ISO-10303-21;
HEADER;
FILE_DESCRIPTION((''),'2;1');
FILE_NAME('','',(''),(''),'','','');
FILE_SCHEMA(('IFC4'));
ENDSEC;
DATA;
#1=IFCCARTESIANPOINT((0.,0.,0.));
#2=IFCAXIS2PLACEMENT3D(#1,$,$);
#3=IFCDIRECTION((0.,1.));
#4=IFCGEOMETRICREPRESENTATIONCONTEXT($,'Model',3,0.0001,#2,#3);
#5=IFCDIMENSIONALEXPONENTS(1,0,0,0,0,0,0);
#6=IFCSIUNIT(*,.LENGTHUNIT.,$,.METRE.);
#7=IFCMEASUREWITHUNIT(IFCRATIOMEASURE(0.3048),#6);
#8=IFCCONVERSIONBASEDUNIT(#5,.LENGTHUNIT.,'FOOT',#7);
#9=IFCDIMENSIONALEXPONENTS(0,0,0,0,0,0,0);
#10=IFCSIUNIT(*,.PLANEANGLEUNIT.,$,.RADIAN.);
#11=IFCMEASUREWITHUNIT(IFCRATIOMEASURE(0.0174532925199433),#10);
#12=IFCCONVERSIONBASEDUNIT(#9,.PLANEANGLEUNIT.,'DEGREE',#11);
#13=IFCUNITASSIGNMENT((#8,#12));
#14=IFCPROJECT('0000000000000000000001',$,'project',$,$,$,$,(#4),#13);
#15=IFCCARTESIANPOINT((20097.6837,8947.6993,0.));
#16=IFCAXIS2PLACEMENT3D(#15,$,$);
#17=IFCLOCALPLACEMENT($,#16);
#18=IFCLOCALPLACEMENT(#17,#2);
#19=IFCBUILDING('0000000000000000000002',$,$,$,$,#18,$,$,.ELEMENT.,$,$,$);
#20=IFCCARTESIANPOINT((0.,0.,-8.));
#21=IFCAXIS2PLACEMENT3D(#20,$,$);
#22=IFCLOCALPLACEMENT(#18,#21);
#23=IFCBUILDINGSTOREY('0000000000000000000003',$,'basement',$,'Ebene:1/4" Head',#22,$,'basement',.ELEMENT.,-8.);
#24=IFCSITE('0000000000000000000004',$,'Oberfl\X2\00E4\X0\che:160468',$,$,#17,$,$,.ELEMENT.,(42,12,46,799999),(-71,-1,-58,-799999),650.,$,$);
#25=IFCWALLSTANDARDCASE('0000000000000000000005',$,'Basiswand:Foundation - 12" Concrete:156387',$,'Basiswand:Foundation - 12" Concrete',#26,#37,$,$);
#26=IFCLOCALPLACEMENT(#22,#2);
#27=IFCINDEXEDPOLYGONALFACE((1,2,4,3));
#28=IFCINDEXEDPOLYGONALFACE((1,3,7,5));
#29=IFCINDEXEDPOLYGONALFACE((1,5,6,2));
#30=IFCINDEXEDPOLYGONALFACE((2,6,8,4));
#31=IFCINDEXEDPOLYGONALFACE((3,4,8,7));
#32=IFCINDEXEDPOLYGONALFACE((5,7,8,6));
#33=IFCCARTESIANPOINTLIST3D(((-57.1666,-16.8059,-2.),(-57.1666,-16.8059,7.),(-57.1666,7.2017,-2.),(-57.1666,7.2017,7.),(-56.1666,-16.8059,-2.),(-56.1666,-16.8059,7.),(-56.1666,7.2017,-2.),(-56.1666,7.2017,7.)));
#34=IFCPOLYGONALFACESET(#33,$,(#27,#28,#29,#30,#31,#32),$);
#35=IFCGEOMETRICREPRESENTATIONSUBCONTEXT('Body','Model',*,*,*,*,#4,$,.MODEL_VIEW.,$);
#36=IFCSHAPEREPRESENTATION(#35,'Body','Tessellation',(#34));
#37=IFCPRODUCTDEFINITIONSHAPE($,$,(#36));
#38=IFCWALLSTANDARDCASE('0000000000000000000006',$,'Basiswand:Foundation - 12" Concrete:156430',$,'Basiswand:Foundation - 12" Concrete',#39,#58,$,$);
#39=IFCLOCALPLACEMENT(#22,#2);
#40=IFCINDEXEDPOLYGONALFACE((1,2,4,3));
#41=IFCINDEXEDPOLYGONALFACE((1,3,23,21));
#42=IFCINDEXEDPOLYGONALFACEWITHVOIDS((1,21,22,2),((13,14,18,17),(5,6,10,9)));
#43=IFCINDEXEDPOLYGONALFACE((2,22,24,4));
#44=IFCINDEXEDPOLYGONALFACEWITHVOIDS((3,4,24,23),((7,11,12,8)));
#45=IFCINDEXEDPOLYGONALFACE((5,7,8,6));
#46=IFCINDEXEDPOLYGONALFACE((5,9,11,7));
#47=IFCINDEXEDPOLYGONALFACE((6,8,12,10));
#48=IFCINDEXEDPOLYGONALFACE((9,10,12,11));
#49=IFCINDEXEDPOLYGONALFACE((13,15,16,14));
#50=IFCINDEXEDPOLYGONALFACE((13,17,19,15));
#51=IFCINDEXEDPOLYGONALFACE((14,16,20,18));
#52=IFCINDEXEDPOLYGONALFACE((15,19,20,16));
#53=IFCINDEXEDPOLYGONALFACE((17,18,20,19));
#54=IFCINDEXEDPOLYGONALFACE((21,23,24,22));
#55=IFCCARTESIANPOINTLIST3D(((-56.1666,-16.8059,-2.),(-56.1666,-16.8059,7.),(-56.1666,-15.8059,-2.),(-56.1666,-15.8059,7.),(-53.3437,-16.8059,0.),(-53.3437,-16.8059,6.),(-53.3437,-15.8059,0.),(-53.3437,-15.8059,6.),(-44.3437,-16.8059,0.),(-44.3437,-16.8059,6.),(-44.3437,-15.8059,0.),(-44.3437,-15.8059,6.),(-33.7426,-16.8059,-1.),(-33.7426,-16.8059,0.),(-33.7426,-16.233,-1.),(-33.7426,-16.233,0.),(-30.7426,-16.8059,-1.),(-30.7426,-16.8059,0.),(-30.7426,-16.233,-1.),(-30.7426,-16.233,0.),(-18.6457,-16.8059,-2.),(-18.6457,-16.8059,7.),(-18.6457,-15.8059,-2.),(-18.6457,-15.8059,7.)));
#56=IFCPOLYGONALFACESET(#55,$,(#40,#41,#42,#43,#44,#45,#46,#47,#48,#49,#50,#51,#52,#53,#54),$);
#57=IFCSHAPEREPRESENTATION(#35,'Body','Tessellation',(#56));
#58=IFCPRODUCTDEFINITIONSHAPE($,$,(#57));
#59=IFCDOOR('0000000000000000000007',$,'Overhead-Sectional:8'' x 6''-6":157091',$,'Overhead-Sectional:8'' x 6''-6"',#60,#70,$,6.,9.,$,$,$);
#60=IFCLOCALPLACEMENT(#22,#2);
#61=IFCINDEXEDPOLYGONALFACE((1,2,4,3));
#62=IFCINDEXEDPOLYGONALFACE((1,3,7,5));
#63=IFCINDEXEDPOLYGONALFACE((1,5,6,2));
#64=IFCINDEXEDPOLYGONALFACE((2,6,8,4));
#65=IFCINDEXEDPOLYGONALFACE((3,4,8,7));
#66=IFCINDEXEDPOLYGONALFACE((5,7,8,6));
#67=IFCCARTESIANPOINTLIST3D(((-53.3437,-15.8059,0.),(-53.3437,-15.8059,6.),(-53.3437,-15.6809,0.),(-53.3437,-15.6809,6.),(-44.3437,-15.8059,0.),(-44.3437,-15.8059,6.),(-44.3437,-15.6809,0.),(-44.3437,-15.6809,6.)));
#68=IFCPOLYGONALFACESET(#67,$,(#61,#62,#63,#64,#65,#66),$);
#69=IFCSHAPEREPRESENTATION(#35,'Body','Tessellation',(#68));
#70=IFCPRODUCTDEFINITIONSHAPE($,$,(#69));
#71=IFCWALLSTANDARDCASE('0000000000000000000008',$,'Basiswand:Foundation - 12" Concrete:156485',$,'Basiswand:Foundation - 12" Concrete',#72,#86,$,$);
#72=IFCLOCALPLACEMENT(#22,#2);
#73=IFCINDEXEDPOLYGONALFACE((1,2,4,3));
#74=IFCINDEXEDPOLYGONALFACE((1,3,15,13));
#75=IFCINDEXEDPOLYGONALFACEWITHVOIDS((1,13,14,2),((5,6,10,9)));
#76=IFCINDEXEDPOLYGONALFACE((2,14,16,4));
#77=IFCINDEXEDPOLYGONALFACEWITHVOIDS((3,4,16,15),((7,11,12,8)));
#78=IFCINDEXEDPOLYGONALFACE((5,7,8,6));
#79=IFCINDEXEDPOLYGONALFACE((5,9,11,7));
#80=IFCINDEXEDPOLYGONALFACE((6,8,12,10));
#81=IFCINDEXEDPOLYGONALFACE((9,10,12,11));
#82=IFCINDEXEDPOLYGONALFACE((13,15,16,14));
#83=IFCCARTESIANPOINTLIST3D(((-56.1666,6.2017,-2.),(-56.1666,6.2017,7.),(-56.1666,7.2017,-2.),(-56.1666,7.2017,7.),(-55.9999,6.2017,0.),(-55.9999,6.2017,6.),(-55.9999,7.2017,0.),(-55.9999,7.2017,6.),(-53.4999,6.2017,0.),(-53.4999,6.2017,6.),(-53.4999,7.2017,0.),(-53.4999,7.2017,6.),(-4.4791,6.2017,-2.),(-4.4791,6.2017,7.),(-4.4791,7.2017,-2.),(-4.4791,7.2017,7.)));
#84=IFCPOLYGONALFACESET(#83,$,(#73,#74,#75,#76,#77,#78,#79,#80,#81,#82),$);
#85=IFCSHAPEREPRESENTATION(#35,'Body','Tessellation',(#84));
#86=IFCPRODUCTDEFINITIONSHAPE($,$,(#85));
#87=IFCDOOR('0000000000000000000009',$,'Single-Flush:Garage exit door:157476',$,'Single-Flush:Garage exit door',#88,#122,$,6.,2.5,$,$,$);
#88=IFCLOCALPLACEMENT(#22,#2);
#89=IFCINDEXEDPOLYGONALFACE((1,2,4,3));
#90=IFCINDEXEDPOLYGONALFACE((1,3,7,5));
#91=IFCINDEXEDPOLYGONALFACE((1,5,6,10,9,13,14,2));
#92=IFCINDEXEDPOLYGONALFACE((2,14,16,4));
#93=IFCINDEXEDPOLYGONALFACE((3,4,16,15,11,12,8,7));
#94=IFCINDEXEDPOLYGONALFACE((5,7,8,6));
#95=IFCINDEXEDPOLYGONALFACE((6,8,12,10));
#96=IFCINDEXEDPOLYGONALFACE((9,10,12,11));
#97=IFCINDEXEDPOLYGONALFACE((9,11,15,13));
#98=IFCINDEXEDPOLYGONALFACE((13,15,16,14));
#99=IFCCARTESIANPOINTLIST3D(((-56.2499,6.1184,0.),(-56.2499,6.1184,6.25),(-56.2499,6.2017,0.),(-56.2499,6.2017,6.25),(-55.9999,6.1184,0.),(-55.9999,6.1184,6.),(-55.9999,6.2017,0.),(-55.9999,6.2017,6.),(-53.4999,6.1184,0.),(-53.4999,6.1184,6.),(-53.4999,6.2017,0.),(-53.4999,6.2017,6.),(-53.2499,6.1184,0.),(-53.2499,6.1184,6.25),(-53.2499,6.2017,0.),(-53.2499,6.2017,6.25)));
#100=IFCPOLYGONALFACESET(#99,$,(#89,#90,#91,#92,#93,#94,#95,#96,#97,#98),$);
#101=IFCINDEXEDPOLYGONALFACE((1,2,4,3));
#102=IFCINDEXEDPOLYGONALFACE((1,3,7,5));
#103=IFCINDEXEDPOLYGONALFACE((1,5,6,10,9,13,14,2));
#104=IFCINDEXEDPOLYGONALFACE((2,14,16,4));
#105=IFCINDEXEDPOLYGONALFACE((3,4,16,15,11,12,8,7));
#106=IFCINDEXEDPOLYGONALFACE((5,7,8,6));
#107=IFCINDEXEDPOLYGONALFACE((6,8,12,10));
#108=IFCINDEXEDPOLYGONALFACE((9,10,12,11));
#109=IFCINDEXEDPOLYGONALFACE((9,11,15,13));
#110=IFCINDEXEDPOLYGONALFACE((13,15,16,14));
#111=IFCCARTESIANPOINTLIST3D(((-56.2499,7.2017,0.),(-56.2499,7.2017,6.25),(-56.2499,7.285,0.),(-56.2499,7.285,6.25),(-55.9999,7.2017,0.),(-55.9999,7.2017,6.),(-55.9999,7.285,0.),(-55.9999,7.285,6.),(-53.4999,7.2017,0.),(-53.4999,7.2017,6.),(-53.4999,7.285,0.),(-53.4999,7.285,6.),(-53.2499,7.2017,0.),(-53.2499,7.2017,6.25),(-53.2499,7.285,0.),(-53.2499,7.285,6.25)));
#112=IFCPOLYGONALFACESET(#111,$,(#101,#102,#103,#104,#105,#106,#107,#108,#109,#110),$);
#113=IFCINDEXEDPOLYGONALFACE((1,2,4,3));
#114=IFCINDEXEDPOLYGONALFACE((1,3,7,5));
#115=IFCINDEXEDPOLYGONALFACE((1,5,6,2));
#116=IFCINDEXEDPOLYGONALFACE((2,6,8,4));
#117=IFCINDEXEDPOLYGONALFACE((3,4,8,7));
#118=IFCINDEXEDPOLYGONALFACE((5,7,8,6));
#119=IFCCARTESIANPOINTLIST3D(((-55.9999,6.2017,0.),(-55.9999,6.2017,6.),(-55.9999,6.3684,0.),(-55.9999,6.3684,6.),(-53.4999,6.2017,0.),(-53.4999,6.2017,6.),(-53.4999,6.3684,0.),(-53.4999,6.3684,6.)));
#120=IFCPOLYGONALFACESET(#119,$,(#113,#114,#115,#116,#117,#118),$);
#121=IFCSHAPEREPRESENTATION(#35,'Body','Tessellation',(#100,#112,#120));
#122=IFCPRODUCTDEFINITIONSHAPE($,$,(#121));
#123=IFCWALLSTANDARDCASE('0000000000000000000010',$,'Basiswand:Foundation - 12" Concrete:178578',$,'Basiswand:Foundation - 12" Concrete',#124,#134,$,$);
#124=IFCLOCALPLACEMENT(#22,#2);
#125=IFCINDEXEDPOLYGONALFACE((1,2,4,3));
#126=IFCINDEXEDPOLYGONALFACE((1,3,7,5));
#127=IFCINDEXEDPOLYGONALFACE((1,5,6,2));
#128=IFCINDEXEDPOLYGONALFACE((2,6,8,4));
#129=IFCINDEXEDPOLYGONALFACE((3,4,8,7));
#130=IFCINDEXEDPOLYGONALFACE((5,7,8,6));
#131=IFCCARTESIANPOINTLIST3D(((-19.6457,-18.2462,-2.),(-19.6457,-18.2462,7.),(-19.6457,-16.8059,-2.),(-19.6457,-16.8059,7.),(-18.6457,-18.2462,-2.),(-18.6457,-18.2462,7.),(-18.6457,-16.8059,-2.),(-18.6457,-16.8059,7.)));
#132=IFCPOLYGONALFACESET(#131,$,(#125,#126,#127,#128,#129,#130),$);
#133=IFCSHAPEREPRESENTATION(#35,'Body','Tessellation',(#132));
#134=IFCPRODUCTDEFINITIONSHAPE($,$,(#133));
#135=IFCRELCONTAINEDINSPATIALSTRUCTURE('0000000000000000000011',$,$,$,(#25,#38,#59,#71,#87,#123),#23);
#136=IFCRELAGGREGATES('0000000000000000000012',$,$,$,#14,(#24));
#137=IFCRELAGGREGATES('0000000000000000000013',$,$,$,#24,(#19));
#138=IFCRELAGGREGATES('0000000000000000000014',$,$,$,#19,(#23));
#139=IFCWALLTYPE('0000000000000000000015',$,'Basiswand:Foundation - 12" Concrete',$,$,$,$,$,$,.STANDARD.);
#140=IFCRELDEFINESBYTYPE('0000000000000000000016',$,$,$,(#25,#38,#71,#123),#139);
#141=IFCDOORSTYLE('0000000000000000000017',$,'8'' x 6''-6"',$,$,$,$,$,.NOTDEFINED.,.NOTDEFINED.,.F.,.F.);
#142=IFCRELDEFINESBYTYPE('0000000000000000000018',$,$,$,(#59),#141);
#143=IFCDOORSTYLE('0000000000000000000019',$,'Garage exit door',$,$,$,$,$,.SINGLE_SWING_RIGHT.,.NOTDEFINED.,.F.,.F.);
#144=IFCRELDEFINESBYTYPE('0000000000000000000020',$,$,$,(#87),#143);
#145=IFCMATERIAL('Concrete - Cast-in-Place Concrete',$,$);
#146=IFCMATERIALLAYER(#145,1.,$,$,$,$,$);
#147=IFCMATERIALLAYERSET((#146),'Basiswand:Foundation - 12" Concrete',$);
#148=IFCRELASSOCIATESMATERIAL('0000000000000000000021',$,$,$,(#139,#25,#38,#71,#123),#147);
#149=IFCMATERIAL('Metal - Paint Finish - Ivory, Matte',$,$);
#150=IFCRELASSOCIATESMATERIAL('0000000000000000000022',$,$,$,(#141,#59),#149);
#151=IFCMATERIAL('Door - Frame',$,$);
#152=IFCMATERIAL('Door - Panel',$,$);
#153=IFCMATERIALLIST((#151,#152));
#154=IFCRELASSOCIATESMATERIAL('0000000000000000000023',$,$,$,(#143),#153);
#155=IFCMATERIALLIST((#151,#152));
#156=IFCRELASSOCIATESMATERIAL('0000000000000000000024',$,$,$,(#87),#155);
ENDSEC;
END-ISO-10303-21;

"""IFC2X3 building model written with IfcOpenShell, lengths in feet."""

from ifc_helpers import new_model, entity, si_unit, converted_unit, direction, frame, frame_2d, origin, origin_2d_with_axis, place, context, subcontext, project, spatial, polyline, rectangle, outline, extrude, source, transform, mapped, material, material_list, layer, layer_set, layer_usage, type_object, type_shapes, element, fill, save


model = new_model("IFC2X3")

# Units and contexts
model_context = context("Model", 3, precision=0.0001, world=origin(), true_north=direction((0.0, 1.0)))
body_context = subcontext(model_context, "Body", "Model", "MODEL_VIEW")
ifc_project = project(units=[converted_unit("LENGTHUNIT", "FOOT", entity("IfcRatioMeasure", 0.3048), si_unit("LENGTHUNIT", "METRE"), dimensions=[1, 0, 0, 0, 0, 0, 0]), converted_unit("PLANEANGLEUNIT", "DEGREE", entity("IfcRatioMeasure", 0.0174532925199433), si_unit("PLANEANGLEUNIT", "RADIAN"), dimensions=[0, 0, 0, 0, 0, 0, 0])], contexts=[model_context])

# Site, building, storey
site_placement = place(None, frame((20097.6837, 8947.6993, 0.0)))
site = spatial("IfcSite", under=ifc_project, at=site_placement, Name="Oberfläche:160468", CompositionType="ELEMENT", RefLatitude=(42, 12, 46, 799999), RefLongitude=(-71, -1, -58, -799999), RefElevation=650.0)
building_placement = place(site_placement, origin())
building = spatial("IfcBuilding", under=site, at=building_placement, CompositionType="ELEMENT")
storey_placement = place(building_placement, frame((0.0, 0.0, -8.0)))
storey = spatial("IfcBuildingStorey", under=building, at=storey_placement, Name="basement", ObjectType="Ebene:1/4\" Head", LongName="basement", CompositionType="ELEMENT", Elevation=-8.0)

# Wall, opening
ifc_material_1 = material(Name="Concrete - Cast-in-Place Concrete")
ifc_layer_1 = layer(ifc_material_1, 1.0)
ifc_layer_set_1 = layer_set([ifc_layer_1], Name="Basiswand:Foundation - 12\" Concrete")
ifc_layer_usage_1 = layer_usage(ifc_layer_set_1, "AXIS2", "POSITIVE", -0.5)
wall_type_1 = type_object("IfcWallType", Name="Basiswand:Foundation - 12\" Concrete", PredefinedType="STANDARD", material=ifc_layer_set_1)
wall_1_placement = place(storey_placement, frame((-56.6666, 7.2017, -2.0), z_axis=(0.0, 0.0, 1.0), x_axis=(0.0, -1.0, 0.0)))
wall_1 = element("IfcWallStandardCase", 1, at=wall_1_placement, inside=storey, type_object=wall_type_1, material=ifc_layer_usage_1, Name="Basiswand:Foundation - 12\" Concrete:156387", ObjectType="Basiswand:Foundation - 12\" Concrete", context=body_context, shape_type="SweptSolid", body=[
    extrude(rectangle(XDim=24.0076, YDim=1.0, at=frame_2d((12.0038, 0.0), x_axis=(-1.0, 0.0))), origin(), (0.0, 0.0, 1.0), 9.0),
])
opening_1_placement = place(wall_1_placement, origin())
element("IfcOpeningElement", 2, at=opening_1_placement, cuts=wall_1, ObjectType="Opening", context=body_context, shape_type="SweptSolid", body=[
    extrude(rectangle(XDim=6.0, YDim=1.0, at=frame_2d((0.0, 0.0), x_axis=(0.0, 1.0))), frame((0.5, 0.6667, 5.0), z_axis=(0.0, 1.0, 0.0), x_axis=(1.0, 0.0, 0.0)), (0.0, 0.0, 1.0), 2.5),
])

# Wall, openings, door
ifc_layer_usage_2 = layer_usage(ifc_layer_set_1, "AXIS2", "POSITIVE", -0.5)
wall_2_placement = place(storey_placement, frame((-56.1666, -16.3059, -2.0)))
wall_2 = element("IfcWallStandardCase", 3, at=wall_2_placement, inside=storey, type_object=wall_type_1, material=ifc_layer_usage_2, Name="Basiswand:Foundation - 12\" Concrete:156430", ObjectType="Basiswand:Foundation - 12\" Concrete", context=body_context, shape_type="SweptSolid", body=[
    extrude(rectangle(XDim=37.5208, YDim=1.0, at=frame_2d((18.7604, 0.0), x_axis=(-1.0, 0.0))), origin(), (0.0, 0.0, 1.0), 9.0),
])
opening_2_placement = place(storey_placement, frame((-56.1666, -16.3059, -2.0)))
element("IfcOpeningElement", 4, at=opening_2_placement, cuts=wall_2, ObjectType="Opening", context=body_context, shape_type="SweptSolid", body=[
    extrude(rectangle(XDim=3.0, YDim=0.5729, at=frame_2d((0.0, 0.0), x_axis=(1.0, 0.0))), frame((23.924, -0.2135, 1.0), z_axis=(0.0, 0.0, 1.0), x_axis=(-1.0, 0.0, 0.0)), (0.0, 0.0, 1.0), 1.0),
])
opening_3_placement = place(wall_2_placement, frame((2.8229, -0.5, 2.0)))
opening_3 = element("IfcOpeningElement", 5, at=opening_3_placement, cuts=wall_2, ObjectType="Opening", context=body_context, shape_type="SweptSolid", body=[
    extrude(rectangle(XDim=6.0, YDim=9.0, at=frame_2d((3.0, 4.5), x_axis=(1.0, 0.0))), frame((0.0, 0.0, 0.0), z_axis=(0.0, 1.0, 0.0), x_axis=(0.0, 0.0, 1.0)), (0.0, 0.0, 1.0), 1.0),
])
ifc_material_2 = material(Name="Metal - Paint Finish - Ivory, Matte")
door_style_1 = type_object("IfcDoorStyle", Name="8' x 6'-6\"", ConstructionType="NOTDEFINED", OperationType="NOTDEFINED", ParameterTakesPrecedence=False, Sizeable=False, material=ifc_material_2)
shared_shape_1 = source(origin(), body_context, "Body", "SweptSolid", [
    extrude(rectangle(XDim=0.125, YDim=9.0, at=origin_2d_with_axis()), frame((4.5, -0.0625, 0.0), z_axis=(0.0, 0.0, 1.0), x_axis=(0.0, -1.0, 0.0)), (0.0, 0.0, 1.0), 6.0),
])
type_shapes(door_style_1, [shared_shape_1])
door_1_placement = place(opening_3_placement, frame((9.0, 1.0, 0.0), z_axis=(0.0, 0.0, 1.0), x_axis=(-1.0, 0.0, 0.0)))
door_1 = element("IfcDoor", 6, at=door_1_placement, inside=storey, type_object=door_style_1, material=ifc_material_2, Name="Overhead-Sectional:8' x 6'-6\":157091", ObjectType="Overhead-Sectional:8' x 6'-6\"", OverallHeight=6.0, OverallWidth=9.0, context=body_context, shape_type="MappedRepresentation", body=[
    mapped(shared_shape_1, transform((0.0, 0.0, 0.0), scale=1.0)),
])
fill(opening_3, door_1)

# Wall, opening, door
ifc_layer_usage_3 = layer_usage(ifc_layer_set_1, "AXIS2", "POSITIVE", -0.5)
wall_3_placement = place(storey_placement, frame((-4.4791, 6.7017, -2.0), z_axis=(0.0, 0.0, 1.0), x_axis=(-1.0, 0.0, 0.0)))
wall_3 = element("IfcWallStandardCase", 7, at=wall_3_placement, inside=storey, type_object=wall_type_1, material=ifc_layer_usage_3, Name="Basiswand:Foundation - 12\" Concrete:156485", ObjectType="Basiswand:Foundation - 12\" Concrete", context=body_context, shape_type="SweptSolid", body=[
    extrude(rectangle(XDim=51.6875, YDim=1.0, at=frame_2d((25.8438, 0.0), x_axis=(-1.0, 0.0))), origin(), (0.0, 0.0, 1.0), 9.0),
])
opening_4_placement = place(wall_3_placement, frame((49.0208, -0.5, 2.0)))
opening_4 = element("IfcOpeningElement", 8, at=opening_4_placement, cuts=wall_3, ObjectType="Opening", context=body_context, shape_type="SweptSolid", body=[
    extrude(rectangle(XDim=2.5, YDim=6.0, at=frame_2d((3.0, 1.25), x_axis=(0.0, 1.0))), frame((0.0, 0.0, 0.0), z_axis=(0.0, 1.0, 0.0), x_axis=(0.0, 0.0, 1.0)), (0.0, 0.0, 1.0), 1.0),
])
ifc_material_3 = material(Name="Door - Frame")
ifc_material_4 = material(Name="Door - Panel")
ifc_material_list_1 = material_list([ifc_material_3, ifc_material_4])
ifc_material_list_2 = material_list([ifc_material_3, ifc_material_4])
door_style_2 = type_object("IfcDoorStyle", Name="Garage exit door", ConstructionType="NOTDEFINED", OperationType="SINGLE_SWING_RIGHT", ParameterTakesPrecedence=False, Sizeable=False, material=ifc_material_list_2)
shared_shape_2 = source(origin(), body_context, "Body", "SweptSolid", [
    extrude(outline(polyline([(-1.5, -3.1875), (1.5, -3.1875), (1.5, 3.0625), (1.25, 3.0625), (1.25, -2.9375), (-1.25, -2.9375), (-1.25, 3.0625), (-1.5, 3.0625), (-1.5, -3.1875)])), frame((1.25, 1.0, 3.0625), z_axis=(0.0, 1.0, 0.0), x_axis=(1.0, 0.0, 0.0)), (0.0, 0.0, 1.0), 0.0833),
    extrude(outline(polyline([(-3.1875, -1.5), (3.0625, -1.5), (3.0625, -1.25), (-2.9375, -1.25), (-2.9375, 1.25), (3.0625, 1.25), (3.0625, 1.5), (-3.1875, 1.5), (-3.1875, -1.5)])), frame((1.25, -0.0833, 3.0625), z_axis=(0.0, 1.0, 0.0), x_axis=(0.0, 0.0, -1.0)), (0.0, 0.0, 1.0), 0.0833),
    extrude(rectangle(XDim=0.1667, YDim=2.5, at=frame_2d((0.0, 0.0), x_axis=(1.0, 0.0))), frame((1.25, 0.9167, 0.0), z_axis=(0.0, 0.0, 1.0), x_axis=(0.0, 1.0, 0.0)), (0.0, 0.0, 1.0), 6.0),
])
type_shapes(door_style_2, [shared_shape_2])
door_2_placement = place(opening_4_placement, origin())
door_2 = element("IfcDoor", 9, at=door_2_placement, inside=storey, type_object=door_style_2, material=ifc_material_list_1, Name="Single-Flush:Garage exit door:157476", ObjectType="Single-Flush:Garage exit door", OverallHeight=6.0, OverallWidth=2.5, context=body_context, shape_type="MappedRepresentation", body=[
    mapped(shared_shape_2, transform((0.0, 0.0, 0.0), scale=1.0)),
])
fill(opening_4, door_2)

# Wall
ifc_layer_usage_4 = layer_usage(ifc_layer_set_1, "AXIS2", "POSITIVE", -0.5)
wall_4_placement = place(storey_placement, frame((-19.1457, -18.2462, -2.0), z_axis=(0.0, 0.0, 1.0), x_axis=(0.0, 1.0, 0.0)))
element("IfcWallStandardCase", 10, at=wall_4_placement, inside=storey, type_object=wall_type_1, material=ifc_layer_usage_4, Name="Basiswand:Foundation - 12\" Concrete:178578", ObjectType="Basiswand:Foundation - 12\" Concrete", context=body_context, shape_type="SweptSolid", body=[
    extrude(rectangle(XDim=1.4403, YDim=1.0, at=frame_2d((0.7202, 0.0), x_axis=(-1.0, 0.0))), origin(), (0.0, 0.0, 1.0), 9.0),
])

save(model, "model.ifc")
